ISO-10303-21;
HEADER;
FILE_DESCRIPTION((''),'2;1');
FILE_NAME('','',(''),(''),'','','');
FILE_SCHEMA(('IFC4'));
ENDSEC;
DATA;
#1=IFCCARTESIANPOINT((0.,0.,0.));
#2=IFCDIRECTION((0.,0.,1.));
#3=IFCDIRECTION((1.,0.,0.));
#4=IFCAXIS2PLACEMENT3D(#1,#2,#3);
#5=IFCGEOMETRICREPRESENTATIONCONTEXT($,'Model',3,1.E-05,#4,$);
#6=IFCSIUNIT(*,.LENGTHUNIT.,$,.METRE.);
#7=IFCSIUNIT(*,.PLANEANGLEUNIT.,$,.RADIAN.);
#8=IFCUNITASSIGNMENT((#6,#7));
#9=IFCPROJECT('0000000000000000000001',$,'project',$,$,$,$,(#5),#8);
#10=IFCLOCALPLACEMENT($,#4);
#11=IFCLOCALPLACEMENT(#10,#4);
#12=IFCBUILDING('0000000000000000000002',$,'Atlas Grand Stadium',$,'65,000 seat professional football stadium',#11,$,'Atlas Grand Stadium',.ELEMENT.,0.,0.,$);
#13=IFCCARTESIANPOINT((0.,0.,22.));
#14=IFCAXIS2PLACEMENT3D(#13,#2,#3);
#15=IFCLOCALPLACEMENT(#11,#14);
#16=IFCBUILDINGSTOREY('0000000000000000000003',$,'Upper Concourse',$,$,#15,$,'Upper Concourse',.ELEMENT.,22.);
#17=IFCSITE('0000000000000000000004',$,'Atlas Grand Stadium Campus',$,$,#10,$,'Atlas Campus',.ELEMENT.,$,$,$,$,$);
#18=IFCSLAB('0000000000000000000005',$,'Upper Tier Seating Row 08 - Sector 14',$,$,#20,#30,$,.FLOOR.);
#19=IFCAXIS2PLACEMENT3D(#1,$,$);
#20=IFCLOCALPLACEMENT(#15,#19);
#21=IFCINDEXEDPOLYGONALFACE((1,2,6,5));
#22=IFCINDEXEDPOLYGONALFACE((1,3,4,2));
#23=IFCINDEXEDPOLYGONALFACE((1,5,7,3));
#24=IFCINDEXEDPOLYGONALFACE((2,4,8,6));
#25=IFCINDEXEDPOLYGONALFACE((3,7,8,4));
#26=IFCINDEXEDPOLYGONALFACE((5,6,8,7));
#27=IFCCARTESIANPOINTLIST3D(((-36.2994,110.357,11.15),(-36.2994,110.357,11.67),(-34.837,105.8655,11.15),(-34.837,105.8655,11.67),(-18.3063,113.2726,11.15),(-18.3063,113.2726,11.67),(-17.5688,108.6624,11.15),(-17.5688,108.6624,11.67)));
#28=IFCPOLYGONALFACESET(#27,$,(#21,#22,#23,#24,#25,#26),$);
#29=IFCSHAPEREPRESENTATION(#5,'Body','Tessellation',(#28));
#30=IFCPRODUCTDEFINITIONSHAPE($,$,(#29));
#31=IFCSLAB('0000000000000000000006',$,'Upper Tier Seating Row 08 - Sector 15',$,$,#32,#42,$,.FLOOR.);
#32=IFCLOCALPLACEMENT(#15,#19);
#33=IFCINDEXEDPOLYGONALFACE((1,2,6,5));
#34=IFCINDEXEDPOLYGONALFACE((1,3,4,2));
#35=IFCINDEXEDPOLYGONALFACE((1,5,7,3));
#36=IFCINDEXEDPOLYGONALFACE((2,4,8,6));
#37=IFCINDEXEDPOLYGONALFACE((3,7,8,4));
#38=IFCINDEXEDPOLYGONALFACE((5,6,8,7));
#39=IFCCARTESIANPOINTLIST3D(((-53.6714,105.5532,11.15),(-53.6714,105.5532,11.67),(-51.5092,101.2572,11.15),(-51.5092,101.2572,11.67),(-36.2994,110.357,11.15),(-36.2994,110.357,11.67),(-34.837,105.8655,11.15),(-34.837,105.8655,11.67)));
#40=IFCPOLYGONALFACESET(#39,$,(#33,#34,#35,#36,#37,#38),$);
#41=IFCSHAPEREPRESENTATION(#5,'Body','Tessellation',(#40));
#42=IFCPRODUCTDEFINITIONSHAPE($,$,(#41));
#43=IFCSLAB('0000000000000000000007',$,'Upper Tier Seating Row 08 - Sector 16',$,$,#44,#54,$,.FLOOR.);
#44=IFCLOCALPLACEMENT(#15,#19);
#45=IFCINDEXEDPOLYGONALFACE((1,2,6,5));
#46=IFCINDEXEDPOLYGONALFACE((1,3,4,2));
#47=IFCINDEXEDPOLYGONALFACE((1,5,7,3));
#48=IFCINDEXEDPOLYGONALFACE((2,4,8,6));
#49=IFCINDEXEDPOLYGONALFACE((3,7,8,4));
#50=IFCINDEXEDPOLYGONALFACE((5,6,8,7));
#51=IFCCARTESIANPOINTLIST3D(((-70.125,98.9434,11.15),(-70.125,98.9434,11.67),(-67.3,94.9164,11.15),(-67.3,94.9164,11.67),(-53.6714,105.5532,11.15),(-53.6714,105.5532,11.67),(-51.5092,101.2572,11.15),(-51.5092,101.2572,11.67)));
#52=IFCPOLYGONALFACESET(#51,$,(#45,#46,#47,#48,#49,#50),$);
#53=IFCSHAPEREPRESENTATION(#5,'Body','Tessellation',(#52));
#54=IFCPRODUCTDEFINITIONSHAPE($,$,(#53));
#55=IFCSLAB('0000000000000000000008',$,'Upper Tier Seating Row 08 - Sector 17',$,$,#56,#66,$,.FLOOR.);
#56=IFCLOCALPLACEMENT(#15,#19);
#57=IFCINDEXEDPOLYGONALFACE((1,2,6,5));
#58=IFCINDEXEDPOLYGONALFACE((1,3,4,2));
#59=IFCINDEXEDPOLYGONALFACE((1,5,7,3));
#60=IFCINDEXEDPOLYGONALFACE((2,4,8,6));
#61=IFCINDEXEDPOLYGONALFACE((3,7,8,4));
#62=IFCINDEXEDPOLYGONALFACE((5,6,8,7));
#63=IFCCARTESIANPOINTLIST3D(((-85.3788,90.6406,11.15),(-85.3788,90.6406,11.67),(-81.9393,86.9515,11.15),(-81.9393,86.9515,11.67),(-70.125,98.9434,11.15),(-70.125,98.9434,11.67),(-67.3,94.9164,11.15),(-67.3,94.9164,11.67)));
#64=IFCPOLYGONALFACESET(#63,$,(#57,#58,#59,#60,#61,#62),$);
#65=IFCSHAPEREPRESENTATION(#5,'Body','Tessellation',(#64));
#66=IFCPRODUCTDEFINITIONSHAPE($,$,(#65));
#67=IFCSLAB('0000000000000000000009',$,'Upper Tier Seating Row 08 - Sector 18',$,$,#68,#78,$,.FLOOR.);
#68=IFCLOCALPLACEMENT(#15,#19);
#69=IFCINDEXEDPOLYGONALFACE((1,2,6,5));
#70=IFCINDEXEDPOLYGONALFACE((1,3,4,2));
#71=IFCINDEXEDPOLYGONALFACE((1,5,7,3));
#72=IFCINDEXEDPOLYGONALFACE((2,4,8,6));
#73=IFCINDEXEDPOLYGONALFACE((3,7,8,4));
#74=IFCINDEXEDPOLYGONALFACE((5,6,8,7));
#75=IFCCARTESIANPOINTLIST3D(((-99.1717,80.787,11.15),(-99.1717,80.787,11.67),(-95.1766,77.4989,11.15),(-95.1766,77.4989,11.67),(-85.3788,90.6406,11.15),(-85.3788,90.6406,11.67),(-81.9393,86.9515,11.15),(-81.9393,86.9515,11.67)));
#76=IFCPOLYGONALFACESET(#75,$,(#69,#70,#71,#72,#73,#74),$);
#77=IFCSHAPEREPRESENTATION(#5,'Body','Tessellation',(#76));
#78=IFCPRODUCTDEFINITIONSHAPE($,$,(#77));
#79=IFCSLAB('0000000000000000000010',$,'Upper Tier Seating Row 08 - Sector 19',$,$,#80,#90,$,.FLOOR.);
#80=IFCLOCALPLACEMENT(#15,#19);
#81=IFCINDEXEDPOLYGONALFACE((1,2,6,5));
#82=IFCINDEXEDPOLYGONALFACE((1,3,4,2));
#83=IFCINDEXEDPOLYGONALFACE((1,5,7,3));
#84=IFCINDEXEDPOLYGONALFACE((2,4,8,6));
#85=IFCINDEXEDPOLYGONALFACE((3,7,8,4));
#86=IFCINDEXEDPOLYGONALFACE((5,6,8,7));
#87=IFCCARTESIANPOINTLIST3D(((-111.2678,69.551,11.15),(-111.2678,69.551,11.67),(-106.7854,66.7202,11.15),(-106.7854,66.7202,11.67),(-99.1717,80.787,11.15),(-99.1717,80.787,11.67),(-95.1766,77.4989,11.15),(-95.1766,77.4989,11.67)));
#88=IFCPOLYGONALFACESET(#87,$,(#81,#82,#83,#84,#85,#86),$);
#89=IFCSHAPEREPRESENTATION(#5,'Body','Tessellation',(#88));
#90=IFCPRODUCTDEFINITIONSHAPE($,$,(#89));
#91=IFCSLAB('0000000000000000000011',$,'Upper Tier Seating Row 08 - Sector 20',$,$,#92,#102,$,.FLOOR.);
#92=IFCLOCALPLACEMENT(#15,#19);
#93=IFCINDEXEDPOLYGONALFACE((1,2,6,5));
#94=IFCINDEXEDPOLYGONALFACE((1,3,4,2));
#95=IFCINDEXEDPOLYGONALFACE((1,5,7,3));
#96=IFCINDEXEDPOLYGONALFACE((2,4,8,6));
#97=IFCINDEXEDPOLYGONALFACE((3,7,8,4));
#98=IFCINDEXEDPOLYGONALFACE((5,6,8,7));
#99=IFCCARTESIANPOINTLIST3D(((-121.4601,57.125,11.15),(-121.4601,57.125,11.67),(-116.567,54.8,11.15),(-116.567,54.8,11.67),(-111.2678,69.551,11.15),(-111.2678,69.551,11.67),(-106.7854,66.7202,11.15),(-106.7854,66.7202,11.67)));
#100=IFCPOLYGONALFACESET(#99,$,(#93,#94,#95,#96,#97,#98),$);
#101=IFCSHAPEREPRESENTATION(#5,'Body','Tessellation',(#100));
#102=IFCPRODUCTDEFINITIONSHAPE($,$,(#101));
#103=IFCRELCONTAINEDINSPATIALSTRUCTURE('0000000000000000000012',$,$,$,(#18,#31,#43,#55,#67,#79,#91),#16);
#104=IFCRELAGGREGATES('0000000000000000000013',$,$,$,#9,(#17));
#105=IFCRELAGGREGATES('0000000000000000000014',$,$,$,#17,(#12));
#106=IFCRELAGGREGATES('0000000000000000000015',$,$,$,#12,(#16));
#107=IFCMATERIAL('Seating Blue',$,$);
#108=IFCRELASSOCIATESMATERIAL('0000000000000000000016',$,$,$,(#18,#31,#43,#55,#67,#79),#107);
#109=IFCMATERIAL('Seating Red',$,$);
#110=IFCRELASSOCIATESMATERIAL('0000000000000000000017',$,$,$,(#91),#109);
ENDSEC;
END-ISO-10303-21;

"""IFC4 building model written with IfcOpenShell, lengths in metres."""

from ifc_helpers import new_model, si_unit, frame, origin_with_axes, place, context, project, spatial, polyline, outline, extrude, material, element, save


model = new_model("IFC4")

# Units and contexts
model_context = context("Model", 3, precision=1e-05, world=origin_with_axes())
ifc_project = project(units=[si_unit("LENGTHUNIT", "METRE"), si_unit("PLANEANGLEUNIT", "RADIAN")], contexts=[model_context])

# Site, building, storey
site_placement = place(None, origin_with_axes())
site = spatial("IfcSite", under=ifc_project, at=site_placement, Name="Atlas Grand Stadium Campus", LongName="Atlas Campus", CompositionType="ELEMENT")
building_placement = place(site_placement, origin_with_axes())
building = spatial("IfcBuilding", under=site, at=building_placement, Name="Atlas Grand Stadium", ObjectType="65,000 seat professional football stadium", LongName="Atlas Grand Stadium", CompositionType="ELEMENT", ElevationOfRefHeight=0.0, ElevationOfTerrain=0.0)
storey_placement = place(building_placement, frame((0.0, 0.0, 22.0), z_axis=(0.0, 0.0, 1.0), x_axis=(1.0, 0.0, 0.0)))
storey = spatial("IfcBuildingStorey", under=building, at=storey_placement, Name="Upper Concourse", LongName="Upper Concourse", CompositionType="ELEMENT", Elevation=22.0)

# Slabs
ifc_material_1 = material(Name="Seating Red")
ifc_material_2 = material(Name="Seating Blue")
slab_1_placement = place(storey_placement, frame((0.0, 0.0, 11.15), z_axis=(0.0, 0.0, 1.0), x_axis=(1.0, 0.0, 0.0)))
element("IfcSlab", 1, at=slab_1_placement, inside=storey, material=ifc_material_2, Name="Upper Tier Seating Row 08 - Sector 14", PredefinedType="FLOOR", context=model_context, shape_type="SweptSolid", body=[
    extrude(outline(polyline([(-18.3063, 113.2726), (-36.2994, 110.357), (-34.837, 105.8655), (-17.5688, 108.6624), (-18.3063, 113.2726)])), origin_with_axes(), (0.0, 0.0, 1.0), 0.52),
])
slab_2_placement = place(storey_placement, frame((0.0, 0.0, 11.15), z_axis=(0.0, 0.0, 1.0), x_axis=(1.0, 0.0, 0.0)))
element("IfcSlab", 2, at=slab_2_placement, inside=storey, material=ifc_material_2, Name="Upper Tier Seating Row 08 - Sector 15", PredefinedType="FLOOR", context=model_context, shape_type="SweptSolid", body=[
    extrude(outline(polyline([(-36.2994, 110.357), (-53.6713, 105.5532), (-51.5092, 101.2572), (-34.837, 105.8655), (-36.2994, 110.357)])), origin_with_axes(), (0.0, 0.0, 1.0), 0.52),
])
slab_3_placement = place(storey_placement, frame((0.0, 0.0, 11.15), z_axis=(0.0, 0.0, 1.0), x_axis=(1.0, 0.0, 0.0)))
element("IfcSlab", 3, at=slab_3_placement, inside=storey, material=ifc_material_2, Name="Upper Tier Seating Row 08 - Sector 16", PredefinedType="FLOOR", context=model_context, shape_type="SweptSolid", body=[
    extrude(outline(polyline([(-53.6713, 105.5532), (-70.125, 98.9434), (-67.3, 94.9164), (-51.5092, 101.2572), (-53.6713, 105.5532)])), origin_with_axes(), (0.0, 0.0, 1.0), 0.52),
])
slab_4_placement = place(storey_placement, frame((0.0, 0.0, 11.15), z_axis=(0.0, 0.0, 1.0), x_axis=(1.0, 0.0, 0.0)))
element("IfcSlab", 4, at=slab_4_placement, inside=storey, material=ifc_material_2, Name="Upper Tier Seating Row 08 - Sector 17", PredefinedType="FLOOR", context=model_context, shape_type="SweptSolid", body=[
    extrude(outline(polyline([(-70.125, 98.9434), (-85.3788, 90.6406), (-81.9393, 86.9515), (-67.3, 94.9164), (-70.125, 98.9434)])), origin_with_axes(), (0.0, 0.0, 1.0), 0.52),
])
slab_5_placement = place(storey_placement, frame((0.0, 0.0, 11.15), z_axis=(0.0, 0.0, 1.0), x_axis=(1.0, 0.0, 0.0)))
element("IfcSlab", 5, at=slab_5_placement, inside=storey, material=ifc_material_2, Name="Upper Tier Seating Row 08 - Sector 18", PredefinedType="FLOOR", context=model_context, shape_type="SweptSolid", body=[
    extrude(outline(polyline([(-85.3788, 90.6406), (-99.1717, 80.787), (-95.1766, 77.4989), (-81.9393, 86.9515), (-85.3788, 90.6406)])), origin_with_axes(), (0.0, 0.0, 1.0), 0.52),
])
slab_6_placement = place(storey_placement, frame((0.0, 0.0, 11.15), z_axis=(0.0, 0.0, 1.0), x_axis=(1.0, 0.0, 0.0)))
element("IfcSlab", 6, at=slab_6_placement, inside=storey, material=ifc_material_2, Name="Upper Tier Seating Row 08 - Sector 19", PredefinedType="FLOOR", context=model_context, shape_type="SweptSolid", body=[
    extrude(outline(polyline([(-99.1717, 80.787), (-111.2678, 69.551), (-106.7854, 66.7202), (-95.1766, 77.4989), (-99.1717, 80.787)])), origin_with_axes(), (0.0, 0.0, 1.0), 0.52),
])
slab_7_placement = place(storey_placement, frame((0.0, 0.0, 11.15), z_axis=(0.0, 0.0, 1.0), x_axis=(1.0, 0.0, 0.0)))
element("IfcSlab", 7, at=slab_7_placement, inside=storey, material=ifc_material_1, Name="Upper Tier Seating Row 08 - Sector 20", PredefinedType="FLOOR", context=model_context, shape_type="SweptSolid", body=[
    extrude(outline(polyline([(-111.2678, 69.551), (-121.4601, 57.125), (-116.567, 54.8), (-106.7854, 66.7202), (-111.2678, 69.551)])), origin_with_axes(), (0.0, 0.0, 1.0), 0.52),
])

save(model, "model.ifc")
